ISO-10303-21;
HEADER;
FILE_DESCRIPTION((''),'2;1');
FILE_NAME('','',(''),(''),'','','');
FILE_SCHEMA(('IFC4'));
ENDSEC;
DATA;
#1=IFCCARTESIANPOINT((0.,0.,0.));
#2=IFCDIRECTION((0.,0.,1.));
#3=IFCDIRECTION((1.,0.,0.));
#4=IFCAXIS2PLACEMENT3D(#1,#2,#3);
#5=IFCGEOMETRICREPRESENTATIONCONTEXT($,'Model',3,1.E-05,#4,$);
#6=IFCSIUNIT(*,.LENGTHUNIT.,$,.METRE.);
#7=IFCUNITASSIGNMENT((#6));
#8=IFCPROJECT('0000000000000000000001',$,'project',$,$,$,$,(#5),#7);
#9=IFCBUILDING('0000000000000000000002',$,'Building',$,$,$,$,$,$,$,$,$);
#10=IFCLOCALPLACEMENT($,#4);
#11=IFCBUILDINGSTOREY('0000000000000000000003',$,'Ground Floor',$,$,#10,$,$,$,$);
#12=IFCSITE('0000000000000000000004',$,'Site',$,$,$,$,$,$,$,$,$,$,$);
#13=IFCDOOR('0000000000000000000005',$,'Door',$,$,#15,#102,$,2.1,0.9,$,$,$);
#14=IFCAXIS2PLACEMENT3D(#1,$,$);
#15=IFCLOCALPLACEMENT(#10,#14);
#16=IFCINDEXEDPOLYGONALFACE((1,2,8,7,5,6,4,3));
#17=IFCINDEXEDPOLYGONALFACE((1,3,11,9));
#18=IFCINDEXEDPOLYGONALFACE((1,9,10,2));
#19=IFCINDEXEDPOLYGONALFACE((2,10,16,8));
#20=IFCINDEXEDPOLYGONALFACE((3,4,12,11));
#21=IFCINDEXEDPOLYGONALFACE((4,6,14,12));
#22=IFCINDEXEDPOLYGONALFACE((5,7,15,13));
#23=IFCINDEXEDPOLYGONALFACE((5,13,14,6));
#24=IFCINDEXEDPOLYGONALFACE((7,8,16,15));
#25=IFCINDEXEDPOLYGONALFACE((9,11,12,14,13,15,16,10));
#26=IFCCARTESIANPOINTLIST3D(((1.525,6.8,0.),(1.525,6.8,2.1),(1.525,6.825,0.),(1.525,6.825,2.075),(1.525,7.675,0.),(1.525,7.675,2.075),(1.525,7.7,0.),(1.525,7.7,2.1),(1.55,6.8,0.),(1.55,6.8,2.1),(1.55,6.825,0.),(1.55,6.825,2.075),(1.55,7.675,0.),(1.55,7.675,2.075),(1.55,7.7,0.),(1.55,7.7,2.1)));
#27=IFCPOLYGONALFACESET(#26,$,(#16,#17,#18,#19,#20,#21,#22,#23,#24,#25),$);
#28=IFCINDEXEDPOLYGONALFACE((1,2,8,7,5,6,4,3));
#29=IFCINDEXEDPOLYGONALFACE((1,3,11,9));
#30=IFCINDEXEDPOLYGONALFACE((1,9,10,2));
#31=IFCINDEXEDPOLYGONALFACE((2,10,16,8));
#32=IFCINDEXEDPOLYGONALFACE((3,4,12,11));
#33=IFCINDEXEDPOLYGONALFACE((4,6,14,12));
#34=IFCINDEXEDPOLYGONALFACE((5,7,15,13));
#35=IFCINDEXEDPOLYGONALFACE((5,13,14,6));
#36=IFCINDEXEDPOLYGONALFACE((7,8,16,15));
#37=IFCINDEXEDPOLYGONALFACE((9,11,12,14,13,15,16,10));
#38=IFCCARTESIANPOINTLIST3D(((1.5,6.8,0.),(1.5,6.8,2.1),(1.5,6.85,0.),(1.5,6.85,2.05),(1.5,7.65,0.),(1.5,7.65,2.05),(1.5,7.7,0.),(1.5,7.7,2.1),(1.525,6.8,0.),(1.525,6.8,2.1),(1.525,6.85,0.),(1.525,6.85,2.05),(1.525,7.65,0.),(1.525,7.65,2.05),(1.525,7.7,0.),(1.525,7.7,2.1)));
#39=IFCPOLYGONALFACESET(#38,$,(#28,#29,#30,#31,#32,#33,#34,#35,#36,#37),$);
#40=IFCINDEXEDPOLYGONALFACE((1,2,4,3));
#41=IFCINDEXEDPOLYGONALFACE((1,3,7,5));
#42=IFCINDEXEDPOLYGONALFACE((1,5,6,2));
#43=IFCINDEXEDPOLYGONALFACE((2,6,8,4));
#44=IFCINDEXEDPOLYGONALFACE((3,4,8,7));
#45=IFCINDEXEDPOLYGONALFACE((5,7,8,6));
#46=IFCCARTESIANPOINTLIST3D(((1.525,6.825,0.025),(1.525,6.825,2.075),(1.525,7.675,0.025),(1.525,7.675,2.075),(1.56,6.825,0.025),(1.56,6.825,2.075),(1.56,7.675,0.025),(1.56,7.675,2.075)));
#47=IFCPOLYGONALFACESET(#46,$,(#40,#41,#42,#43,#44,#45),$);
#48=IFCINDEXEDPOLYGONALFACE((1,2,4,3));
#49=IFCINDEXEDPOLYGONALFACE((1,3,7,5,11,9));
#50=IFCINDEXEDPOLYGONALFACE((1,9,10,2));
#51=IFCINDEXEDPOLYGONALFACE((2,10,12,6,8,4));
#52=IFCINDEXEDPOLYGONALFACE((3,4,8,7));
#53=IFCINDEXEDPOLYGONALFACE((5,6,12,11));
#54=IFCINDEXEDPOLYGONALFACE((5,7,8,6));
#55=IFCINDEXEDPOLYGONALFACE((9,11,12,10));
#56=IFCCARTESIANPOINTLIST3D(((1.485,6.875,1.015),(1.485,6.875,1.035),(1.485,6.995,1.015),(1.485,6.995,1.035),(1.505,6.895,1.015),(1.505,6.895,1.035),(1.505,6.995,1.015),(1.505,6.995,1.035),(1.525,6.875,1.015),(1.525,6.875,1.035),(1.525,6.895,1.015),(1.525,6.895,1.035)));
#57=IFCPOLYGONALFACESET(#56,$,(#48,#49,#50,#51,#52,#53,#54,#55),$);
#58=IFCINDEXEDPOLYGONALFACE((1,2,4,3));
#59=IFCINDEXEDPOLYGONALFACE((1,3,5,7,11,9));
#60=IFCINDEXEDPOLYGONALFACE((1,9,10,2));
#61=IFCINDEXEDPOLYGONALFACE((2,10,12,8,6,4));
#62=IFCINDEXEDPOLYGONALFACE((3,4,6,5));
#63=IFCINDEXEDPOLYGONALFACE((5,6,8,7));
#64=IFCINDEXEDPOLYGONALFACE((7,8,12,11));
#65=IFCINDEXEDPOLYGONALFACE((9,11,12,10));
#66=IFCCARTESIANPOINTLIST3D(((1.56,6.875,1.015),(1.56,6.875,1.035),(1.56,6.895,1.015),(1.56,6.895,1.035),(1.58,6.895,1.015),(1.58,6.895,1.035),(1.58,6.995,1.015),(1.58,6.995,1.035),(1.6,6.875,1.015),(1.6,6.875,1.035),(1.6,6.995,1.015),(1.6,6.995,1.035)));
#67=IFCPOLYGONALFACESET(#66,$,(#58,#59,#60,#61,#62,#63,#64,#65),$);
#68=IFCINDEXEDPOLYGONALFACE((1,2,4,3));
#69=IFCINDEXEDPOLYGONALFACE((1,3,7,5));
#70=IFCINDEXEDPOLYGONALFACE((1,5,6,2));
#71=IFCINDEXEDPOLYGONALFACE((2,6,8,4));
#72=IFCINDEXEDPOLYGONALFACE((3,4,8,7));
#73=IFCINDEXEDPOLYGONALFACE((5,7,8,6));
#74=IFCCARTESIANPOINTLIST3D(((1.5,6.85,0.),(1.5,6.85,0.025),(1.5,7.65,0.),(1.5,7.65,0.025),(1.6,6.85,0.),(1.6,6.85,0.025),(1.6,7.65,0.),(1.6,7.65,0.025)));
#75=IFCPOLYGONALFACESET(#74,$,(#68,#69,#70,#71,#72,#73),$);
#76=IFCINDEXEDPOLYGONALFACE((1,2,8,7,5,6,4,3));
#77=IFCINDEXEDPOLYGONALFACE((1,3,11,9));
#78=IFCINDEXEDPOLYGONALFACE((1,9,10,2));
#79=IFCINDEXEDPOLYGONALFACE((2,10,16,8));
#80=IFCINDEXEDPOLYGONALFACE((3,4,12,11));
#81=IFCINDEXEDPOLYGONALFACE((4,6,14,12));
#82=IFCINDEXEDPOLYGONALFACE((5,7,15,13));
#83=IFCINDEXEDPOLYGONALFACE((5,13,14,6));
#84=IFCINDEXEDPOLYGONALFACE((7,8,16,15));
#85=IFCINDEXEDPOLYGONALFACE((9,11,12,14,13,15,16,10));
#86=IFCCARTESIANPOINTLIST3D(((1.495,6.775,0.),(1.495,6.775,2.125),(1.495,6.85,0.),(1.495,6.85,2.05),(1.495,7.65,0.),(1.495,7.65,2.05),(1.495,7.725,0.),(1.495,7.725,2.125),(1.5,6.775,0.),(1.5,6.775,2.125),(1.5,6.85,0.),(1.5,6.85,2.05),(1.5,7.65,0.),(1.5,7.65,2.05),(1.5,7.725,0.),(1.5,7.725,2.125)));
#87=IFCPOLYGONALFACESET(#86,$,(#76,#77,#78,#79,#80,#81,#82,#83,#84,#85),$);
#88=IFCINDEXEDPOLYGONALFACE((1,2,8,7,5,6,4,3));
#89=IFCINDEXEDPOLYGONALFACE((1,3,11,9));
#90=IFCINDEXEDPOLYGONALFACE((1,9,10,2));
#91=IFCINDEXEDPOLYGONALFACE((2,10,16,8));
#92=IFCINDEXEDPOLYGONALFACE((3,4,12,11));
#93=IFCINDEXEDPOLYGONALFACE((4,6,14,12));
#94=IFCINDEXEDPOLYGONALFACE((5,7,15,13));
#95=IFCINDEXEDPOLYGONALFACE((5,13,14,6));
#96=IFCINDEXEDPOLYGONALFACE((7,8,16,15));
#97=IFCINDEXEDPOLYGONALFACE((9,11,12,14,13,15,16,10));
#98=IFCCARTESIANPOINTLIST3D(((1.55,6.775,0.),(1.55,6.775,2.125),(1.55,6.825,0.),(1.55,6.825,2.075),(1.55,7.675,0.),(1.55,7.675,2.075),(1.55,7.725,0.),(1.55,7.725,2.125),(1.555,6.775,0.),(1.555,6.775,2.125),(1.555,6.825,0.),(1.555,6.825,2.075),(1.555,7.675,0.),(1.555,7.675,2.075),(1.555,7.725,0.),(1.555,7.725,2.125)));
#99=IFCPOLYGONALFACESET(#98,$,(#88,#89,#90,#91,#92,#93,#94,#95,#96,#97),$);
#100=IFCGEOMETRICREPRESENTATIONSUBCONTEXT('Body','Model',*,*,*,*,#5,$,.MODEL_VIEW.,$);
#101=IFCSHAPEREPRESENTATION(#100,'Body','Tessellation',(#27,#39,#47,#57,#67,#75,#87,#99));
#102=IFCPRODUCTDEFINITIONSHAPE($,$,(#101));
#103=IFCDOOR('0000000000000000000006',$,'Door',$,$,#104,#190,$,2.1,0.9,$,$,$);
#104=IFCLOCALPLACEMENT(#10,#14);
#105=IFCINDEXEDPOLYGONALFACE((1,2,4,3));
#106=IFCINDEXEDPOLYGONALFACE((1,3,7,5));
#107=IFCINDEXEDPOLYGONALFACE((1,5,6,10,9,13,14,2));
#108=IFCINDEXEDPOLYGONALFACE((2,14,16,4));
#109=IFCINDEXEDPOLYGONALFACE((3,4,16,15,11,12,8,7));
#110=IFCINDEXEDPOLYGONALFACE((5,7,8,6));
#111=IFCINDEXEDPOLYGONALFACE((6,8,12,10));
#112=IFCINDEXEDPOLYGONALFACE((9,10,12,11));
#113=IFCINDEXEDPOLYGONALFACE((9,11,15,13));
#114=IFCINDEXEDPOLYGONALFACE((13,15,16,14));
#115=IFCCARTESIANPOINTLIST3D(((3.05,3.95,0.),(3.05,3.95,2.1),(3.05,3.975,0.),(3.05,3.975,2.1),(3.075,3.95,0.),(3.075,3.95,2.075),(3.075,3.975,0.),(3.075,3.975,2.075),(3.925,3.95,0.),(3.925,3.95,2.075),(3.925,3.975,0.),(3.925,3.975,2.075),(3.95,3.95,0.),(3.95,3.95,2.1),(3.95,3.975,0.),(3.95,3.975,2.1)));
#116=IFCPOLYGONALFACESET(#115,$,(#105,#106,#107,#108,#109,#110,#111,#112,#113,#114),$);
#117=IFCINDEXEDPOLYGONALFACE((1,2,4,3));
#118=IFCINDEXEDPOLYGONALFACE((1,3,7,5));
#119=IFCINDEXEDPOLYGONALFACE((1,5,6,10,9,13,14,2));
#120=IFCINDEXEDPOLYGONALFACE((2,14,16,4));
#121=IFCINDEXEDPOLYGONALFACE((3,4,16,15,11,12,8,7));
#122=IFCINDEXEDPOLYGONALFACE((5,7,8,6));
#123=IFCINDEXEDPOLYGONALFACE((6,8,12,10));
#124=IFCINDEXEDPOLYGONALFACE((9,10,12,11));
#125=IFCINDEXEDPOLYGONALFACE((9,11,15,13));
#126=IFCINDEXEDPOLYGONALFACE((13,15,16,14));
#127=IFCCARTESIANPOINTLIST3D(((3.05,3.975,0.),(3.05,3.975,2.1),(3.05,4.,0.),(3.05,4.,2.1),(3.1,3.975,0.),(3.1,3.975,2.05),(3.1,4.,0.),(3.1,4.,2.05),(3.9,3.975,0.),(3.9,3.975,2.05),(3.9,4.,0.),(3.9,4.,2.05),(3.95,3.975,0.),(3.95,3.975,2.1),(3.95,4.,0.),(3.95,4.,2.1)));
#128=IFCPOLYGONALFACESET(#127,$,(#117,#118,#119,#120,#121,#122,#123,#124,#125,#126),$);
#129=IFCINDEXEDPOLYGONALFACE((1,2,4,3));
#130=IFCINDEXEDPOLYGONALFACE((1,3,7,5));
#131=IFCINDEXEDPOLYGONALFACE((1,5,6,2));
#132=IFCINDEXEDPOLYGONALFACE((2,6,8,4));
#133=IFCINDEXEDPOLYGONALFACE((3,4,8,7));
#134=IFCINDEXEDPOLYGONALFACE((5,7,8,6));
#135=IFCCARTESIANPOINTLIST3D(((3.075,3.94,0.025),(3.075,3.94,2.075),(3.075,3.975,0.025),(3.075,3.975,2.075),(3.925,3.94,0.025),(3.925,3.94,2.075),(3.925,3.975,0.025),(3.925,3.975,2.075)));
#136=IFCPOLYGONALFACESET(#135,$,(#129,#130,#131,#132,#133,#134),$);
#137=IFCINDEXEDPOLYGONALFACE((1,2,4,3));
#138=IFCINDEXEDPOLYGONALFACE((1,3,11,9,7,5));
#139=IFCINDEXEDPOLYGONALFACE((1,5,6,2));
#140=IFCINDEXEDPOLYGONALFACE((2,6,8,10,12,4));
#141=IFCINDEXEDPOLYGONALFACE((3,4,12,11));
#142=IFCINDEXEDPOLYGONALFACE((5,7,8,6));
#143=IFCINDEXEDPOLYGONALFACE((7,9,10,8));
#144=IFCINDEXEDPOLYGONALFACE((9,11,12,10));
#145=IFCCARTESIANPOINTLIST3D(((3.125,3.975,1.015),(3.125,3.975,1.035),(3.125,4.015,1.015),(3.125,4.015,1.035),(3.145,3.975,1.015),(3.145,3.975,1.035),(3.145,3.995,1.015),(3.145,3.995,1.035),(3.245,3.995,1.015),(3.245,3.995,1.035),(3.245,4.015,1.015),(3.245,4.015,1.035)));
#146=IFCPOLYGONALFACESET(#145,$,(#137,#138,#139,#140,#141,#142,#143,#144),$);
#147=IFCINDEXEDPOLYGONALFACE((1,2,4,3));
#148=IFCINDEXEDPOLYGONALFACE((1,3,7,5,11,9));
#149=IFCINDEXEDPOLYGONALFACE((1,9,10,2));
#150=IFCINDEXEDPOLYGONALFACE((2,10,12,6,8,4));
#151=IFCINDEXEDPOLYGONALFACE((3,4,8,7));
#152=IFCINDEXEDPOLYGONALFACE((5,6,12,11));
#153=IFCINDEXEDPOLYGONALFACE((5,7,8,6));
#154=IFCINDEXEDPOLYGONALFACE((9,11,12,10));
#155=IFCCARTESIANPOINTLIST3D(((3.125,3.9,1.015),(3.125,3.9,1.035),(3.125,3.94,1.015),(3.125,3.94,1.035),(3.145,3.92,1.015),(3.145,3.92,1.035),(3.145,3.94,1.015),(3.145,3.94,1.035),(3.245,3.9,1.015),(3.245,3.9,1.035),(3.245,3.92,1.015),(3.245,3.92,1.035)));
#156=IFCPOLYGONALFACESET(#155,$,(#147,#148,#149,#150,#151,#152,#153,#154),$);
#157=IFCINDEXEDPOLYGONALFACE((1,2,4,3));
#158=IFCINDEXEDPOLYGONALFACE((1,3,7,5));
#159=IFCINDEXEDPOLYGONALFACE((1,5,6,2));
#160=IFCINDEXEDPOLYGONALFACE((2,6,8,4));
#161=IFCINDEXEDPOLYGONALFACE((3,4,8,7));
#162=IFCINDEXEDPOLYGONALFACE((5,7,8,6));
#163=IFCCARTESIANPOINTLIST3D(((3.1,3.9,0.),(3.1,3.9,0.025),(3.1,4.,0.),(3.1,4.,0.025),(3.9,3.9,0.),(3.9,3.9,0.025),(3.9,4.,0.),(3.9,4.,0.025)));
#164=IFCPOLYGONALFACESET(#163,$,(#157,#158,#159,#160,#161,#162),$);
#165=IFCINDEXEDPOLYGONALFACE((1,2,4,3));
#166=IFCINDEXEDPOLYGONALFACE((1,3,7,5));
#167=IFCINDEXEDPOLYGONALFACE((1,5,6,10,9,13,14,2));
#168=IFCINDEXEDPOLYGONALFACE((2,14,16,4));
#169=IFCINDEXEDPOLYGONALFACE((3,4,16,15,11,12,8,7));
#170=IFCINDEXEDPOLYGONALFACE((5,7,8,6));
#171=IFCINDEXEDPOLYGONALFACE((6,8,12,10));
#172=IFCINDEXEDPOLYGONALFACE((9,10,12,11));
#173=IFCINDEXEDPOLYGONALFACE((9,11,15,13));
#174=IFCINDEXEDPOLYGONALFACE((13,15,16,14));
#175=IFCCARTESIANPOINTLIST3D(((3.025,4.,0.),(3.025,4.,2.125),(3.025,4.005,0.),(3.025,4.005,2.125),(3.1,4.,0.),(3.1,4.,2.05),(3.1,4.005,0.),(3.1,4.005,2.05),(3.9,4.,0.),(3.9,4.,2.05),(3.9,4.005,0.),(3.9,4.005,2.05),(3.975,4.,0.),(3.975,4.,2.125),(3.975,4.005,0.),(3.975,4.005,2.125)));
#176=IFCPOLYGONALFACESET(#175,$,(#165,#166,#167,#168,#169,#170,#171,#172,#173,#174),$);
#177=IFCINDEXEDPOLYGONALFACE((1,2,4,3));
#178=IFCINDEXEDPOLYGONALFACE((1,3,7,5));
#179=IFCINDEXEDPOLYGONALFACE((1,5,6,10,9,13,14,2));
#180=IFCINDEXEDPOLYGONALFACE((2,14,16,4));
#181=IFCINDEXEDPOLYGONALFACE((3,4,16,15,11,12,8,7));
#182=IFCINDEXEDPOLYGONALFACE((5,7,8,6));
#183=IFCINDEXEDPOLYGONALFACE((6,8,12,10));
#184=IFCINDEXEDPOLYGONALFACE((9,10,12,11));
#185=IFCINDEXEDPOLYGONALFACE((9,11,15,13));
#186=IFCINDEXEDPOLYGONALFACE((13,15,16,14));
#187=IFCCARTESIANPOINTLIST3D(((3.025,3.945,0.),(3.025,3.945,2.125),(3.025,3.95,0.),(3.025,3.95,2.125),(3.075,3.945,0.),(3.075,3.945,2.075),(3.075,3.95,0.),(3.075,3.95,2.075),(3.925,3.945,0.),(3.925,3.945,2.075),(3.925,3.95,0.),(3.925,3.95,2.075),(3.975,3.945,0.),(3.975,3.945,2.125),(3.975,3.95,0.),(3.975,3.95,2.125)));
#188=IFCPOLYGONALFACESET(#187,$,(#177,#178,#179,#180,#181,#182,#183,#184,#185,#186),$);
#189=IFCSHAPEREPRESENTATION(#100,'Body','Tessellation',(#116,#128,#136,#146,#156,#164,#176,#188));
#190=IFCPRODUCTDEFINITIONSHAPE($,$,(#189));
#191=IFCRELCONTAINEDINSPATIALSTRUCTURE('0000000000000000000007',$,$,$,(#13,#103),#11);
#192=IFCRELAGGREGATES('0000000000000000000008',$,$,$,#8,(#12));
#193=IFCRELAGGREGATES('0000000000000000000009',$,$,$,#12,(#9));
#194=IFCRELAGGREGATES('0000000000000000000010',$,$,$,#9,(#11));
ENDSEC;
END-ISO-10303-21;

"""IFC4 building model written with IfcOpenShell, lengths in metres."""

from ifc_helpers import new_model, si_unit, frame, origin_with_axes, place, context, subcontext, project, spatial, line, indexed_curve, outline, extrude, element, save


model = new_model("IFC4")

# Units and contexts
model_context = context("Model", 3, precision=1e-05, world=origin_with_axes())
body_context = subcontext(model_context, "Body", "Model", "MODEL_VIEW")
ifc_project = project(units=[si_unit("LENGTHUNIT", "METRE")], contexts=[model_context])

# Site, building, storey
site = spatial("IfcSite", under=ifc_project, Name="Site")
building = spatial("IfcBuilding", under=site, Name="Building")
storey_placement = place(None, origin_with_axes())
storey = spatial("IfcBuildingStorey", under=building, at=storey_placement, Name="Ground Floor")

# Doors
door_1_placement = place(storey_placement, frame((1.5, 7.7, 0.0), z_axis=(0.0, 0.0, 1.0), x_axis=(0.0, -1.0, 0.0)))
element("IfcDoor", 1, at=door_1_placement, inside=storey, Name="Door", OverallHeight=2.1, OverallWidth=0.9, context=body_context, shape_type="SweptSolid", body=[
    extrude(outline(indexed_curve([(0.0, 0.0), (0.0, 2.1), (0.9, 2.1), (0.9, 0.0), (0.875, 0.0), (0.875, 2.075), (0.025, 2.075), (0.025, 0.0)], segments=[line(1, 2, 3, 4, 5, 6, 7, 8, 1)])), frame((0.0, 0.025, 0.0), z_axis=(0.0, -1.0, 0.0), x_axis=(1.0, 0.0, 0.0)), (0.0, 0.0, -1.0), 0.025),
    extrude(outline(indexed_curve([(0.0, 0.0), (0.0, 2.1), (0.9, 2.1), (0.9, 0.0), (0.85, 0.0), (0.85, 2.05), (0.05, 2.05), (0.05, 0.0)], segments=[line(1, 2, 3, 4, 5, 6, 7, 8, 1)])), frame((0.0, 0.0, 0.0), z_axis=(0.0, -1.0, 0.0), x_axis=(1.0, 0.0, 0.0)), (0.0, 0.0, -1.0), 0.025),
    extrude(outline(indexed_curve([(0.0, 0.0), (0.85, 0.0), (0.85, 0.035), (0.0, 0.035)], segments=[line(1, 2, 3, 4, 1)])), frame((0.025, 0.025, 0.025), z_axis=(0.0, 0.0, 1.0), x_axis=(1.0, 0.0, 0.0)), (0.0, 0.0, 1.0), 2.05),
    extrude(outline(indexed_curve([(0.0, 0.0), (0.0, -0.04), (-0.12, -0.04), (-0.12, -0.02), (-0.02, -0.02), (-0.02, 0.0)], segments=[line(1, 2, 3, 4, 5, 6, 1)])), frame((0.825, 0.025, 1.015), z_axis=(0.0, 0.0, 1.0), x_axis=(1.0, 0.0, 0.0)), (0.0, 0.0, 1.0), 0.02),
    extrude(outline(indexed_curve([(0.0, 0.0), (0.0, 0.04), (-0.12, 0.04), (-0.12, 0.02), (-0.02, 0.02), (-0.02, 0.0)], segments=[line(1, 2, 3, 4, 5, 6, 1)])), frame((0.825, 0.06, 1.015), z_axis=(0.0, 0.0, 1.0), x_axis=(1.0, 0.0, 0.0)), (0.0, 0.0, 1.0), 0.02),
    extrude(outline(indexed_curve([(0.0, 0.0), (0.8, 0.0), (0.8, 0.1), (0.0, 0.1)], segments=[line(1, 2, 3, 4, 1)])), frame((0.05, 0.0, 0.0), z_axis=(0.0, 0.0, 1.0), x_axis=(1.0, 0.0, 0.0)), (0.0, 0.0, 1.0), 0.025),
    extrude(outline(indexed_curve([(0.0, 0.0), (0.0, 2.125), (0.95, 2.125), (0.95, 0.0), (0.875, 0.0), (0.875, 2.05), (0.075, 2.05), (0.075, 0.0)], segments=[line(1, 2, 3, 4, 5, 6, 7, 8, 1)])), frame((-0.025, -0.005, 0.0), z_axis=(0.0, -1.0, 0.0), x_axis=(1.0, 0.0, 0.0)), (0.0, 0.0, -1.0), 0.005),
    extrude(outline(indexed_curve([(0.0, 0.0), (0.0, 2.125), (0.95, 2.125), (0.95, 0.0), (0.9, 0.0), (0.9, 2.075), (0.05, 2.075), (0.05, 0.0)], segments=[line(1, 2, 3, 4, 5, 6, 7, 8, 1)])), frame((-0.025, 0.05, 0.0), z_axis=(0.0, -1.0, 0.0), x_axis=(1.0, 0.0, 0.0)), (0.0, 0.0, -1.0), 0.005),
])
door_2_placement = place(storey_placement, frame((3.95, 4.0, 0.0), z_axis=(0.0, 0.0, 1.0), x_axis=(-1.0, 0.0, 0.0)))
element("IfcDoor", 2, at=door_2_placement, inside=storey, Name="Door", OverallHeight=2.1, OverallWidth=0.9, context=body_context, shape_type="SweptSolid", body=[
    extrude(outline(indexed_curve([(0.0, 0.0), (0.0, 2.1), (0.9, 2.1), (0.9, 0.0), (0.875, 0.0), (0.875, 2.075), (0.025, 2.075), (0.025, 0.0)], segments=[line(1, 2, 3, 4, 5, 6, 7, 8, 1)])), frame((0.0, 0.025, 0.0), z_axis=(0.0, -1.0, 0.0), x_axis=(1.0, 0.0, 0.0)), (0.0, 0.0, -1.0), 0.025),
    extrude(outline(indexed_curve([(0.0, 0.0), (0.0, 2.1), (0.9, 2.1), (0.9, 0.0), (0.85, 0.0), (0.85, 2.05), (0.05, 2.05), (0.05, 0.0)], segments=[line(1, 2, 3, 4, 5, 6, 7, 8, 1)])), frame((0.0, 0.0, 0.0), z_axis=(0.0, -1.0, 0.0), x_axis=(1.0, 0.0, 0.0)), (0.0, 0.0, -1.0), 0.025),
    extrude(outline(indexed_curve([(0.0, 0.0), (0.85, 0.0), (0.85, 0.035), (0.0, 0.035)], segments=[line(1, 2, 3, 4, 1)])), frame((0.025, 0.025, 0.025), z_axis=(0.0, 0.0, 1.0), x_axis=(1.0, 0.0, 0.0)), (0.0, 0.0, 1.0), 2.05),
    extrude(outline(indexed_curve([(0.0, 0.0), (0.0, -0.04), (-0.12, -0.04), (-0.12, -0.02), (-0.02, -0.02), (-0.02, 0.0)], segments=[line(1, 2, 3, 4, 5, 6, 1)])), frame((0.825, 0.025, 1.015), z_axis=(0.0, 0.0, 1.0), x_axis=(1.0, 0.0, 0.0)), (0.0, 0.0, 1.0), 0.02),
    extrude(outline(indexed_curve([(0.0, 0.0), (0.0, 0.04), (-0.12, 0.04), (-0.12, 0.02), (-0.02, 0.02), (-0.02, 0.0)], segments=[line(1, 2, 3, 4, 5, 6, 1)])), frame((0.825, 0.06, 1.015), z_axis=(0.0, 0.0, 1.0), x_axis=(1.0, 0.0, 0.0)), (0.0, 0.0, 1.0), 0.02),
    extrude(outline(indexed_curve([(0.0, 0.0), (0.8, 0.0), (0.8, 0.1), (0.0, 0.1)], segments=[line(1, 2, 3, 4, 1)])), frame((0.05, 0.0, 0.0), z_axis=(0.0, 0.0, 1.0), x_axis=(1.0, 0.0, 0.0)), (0.0, 0.0, 1.0), 0.025),
    extrude(outline(indexed_curve([(0.0, 0.0), (0.0, 2.125), (0.95, 2.125), (0.95, 0.0), (0.875, 0.0), (0.875, 2.05), (0.075, 2.05), (0.075, 0.0)], segments=[line(1, 2, 3, 4, 5, 6, 7, 8, 1)])), frame((-0.025, -0.005, 0.0), z_axis=(0.0, -1.0, 0.0), x_axis=(1.0, 0.0, 0.0)), (0.0, 0.0, -1.0), 0.005),
    extrude(outline(indexed_curve([(0.0, 0.0), (0.0, 2.125), (0.95, 2.125), (0.95, 0.0), (0.9, 0.0), (0.9, 2.075), (0.05, 2.075), (0.05, 0.0)], segments=[line(1, 2, 3, 4, 5, 6, 7, 8, 1)])), frame((-0.025, 0.05, 0.0), z_axis=(0.0, -1.0, 0.0), x_axis=(1.0, 0.0, 0.0)), (0.0, 0.0, -1.0), 0.005),
])

save(model, "model.ifc")
